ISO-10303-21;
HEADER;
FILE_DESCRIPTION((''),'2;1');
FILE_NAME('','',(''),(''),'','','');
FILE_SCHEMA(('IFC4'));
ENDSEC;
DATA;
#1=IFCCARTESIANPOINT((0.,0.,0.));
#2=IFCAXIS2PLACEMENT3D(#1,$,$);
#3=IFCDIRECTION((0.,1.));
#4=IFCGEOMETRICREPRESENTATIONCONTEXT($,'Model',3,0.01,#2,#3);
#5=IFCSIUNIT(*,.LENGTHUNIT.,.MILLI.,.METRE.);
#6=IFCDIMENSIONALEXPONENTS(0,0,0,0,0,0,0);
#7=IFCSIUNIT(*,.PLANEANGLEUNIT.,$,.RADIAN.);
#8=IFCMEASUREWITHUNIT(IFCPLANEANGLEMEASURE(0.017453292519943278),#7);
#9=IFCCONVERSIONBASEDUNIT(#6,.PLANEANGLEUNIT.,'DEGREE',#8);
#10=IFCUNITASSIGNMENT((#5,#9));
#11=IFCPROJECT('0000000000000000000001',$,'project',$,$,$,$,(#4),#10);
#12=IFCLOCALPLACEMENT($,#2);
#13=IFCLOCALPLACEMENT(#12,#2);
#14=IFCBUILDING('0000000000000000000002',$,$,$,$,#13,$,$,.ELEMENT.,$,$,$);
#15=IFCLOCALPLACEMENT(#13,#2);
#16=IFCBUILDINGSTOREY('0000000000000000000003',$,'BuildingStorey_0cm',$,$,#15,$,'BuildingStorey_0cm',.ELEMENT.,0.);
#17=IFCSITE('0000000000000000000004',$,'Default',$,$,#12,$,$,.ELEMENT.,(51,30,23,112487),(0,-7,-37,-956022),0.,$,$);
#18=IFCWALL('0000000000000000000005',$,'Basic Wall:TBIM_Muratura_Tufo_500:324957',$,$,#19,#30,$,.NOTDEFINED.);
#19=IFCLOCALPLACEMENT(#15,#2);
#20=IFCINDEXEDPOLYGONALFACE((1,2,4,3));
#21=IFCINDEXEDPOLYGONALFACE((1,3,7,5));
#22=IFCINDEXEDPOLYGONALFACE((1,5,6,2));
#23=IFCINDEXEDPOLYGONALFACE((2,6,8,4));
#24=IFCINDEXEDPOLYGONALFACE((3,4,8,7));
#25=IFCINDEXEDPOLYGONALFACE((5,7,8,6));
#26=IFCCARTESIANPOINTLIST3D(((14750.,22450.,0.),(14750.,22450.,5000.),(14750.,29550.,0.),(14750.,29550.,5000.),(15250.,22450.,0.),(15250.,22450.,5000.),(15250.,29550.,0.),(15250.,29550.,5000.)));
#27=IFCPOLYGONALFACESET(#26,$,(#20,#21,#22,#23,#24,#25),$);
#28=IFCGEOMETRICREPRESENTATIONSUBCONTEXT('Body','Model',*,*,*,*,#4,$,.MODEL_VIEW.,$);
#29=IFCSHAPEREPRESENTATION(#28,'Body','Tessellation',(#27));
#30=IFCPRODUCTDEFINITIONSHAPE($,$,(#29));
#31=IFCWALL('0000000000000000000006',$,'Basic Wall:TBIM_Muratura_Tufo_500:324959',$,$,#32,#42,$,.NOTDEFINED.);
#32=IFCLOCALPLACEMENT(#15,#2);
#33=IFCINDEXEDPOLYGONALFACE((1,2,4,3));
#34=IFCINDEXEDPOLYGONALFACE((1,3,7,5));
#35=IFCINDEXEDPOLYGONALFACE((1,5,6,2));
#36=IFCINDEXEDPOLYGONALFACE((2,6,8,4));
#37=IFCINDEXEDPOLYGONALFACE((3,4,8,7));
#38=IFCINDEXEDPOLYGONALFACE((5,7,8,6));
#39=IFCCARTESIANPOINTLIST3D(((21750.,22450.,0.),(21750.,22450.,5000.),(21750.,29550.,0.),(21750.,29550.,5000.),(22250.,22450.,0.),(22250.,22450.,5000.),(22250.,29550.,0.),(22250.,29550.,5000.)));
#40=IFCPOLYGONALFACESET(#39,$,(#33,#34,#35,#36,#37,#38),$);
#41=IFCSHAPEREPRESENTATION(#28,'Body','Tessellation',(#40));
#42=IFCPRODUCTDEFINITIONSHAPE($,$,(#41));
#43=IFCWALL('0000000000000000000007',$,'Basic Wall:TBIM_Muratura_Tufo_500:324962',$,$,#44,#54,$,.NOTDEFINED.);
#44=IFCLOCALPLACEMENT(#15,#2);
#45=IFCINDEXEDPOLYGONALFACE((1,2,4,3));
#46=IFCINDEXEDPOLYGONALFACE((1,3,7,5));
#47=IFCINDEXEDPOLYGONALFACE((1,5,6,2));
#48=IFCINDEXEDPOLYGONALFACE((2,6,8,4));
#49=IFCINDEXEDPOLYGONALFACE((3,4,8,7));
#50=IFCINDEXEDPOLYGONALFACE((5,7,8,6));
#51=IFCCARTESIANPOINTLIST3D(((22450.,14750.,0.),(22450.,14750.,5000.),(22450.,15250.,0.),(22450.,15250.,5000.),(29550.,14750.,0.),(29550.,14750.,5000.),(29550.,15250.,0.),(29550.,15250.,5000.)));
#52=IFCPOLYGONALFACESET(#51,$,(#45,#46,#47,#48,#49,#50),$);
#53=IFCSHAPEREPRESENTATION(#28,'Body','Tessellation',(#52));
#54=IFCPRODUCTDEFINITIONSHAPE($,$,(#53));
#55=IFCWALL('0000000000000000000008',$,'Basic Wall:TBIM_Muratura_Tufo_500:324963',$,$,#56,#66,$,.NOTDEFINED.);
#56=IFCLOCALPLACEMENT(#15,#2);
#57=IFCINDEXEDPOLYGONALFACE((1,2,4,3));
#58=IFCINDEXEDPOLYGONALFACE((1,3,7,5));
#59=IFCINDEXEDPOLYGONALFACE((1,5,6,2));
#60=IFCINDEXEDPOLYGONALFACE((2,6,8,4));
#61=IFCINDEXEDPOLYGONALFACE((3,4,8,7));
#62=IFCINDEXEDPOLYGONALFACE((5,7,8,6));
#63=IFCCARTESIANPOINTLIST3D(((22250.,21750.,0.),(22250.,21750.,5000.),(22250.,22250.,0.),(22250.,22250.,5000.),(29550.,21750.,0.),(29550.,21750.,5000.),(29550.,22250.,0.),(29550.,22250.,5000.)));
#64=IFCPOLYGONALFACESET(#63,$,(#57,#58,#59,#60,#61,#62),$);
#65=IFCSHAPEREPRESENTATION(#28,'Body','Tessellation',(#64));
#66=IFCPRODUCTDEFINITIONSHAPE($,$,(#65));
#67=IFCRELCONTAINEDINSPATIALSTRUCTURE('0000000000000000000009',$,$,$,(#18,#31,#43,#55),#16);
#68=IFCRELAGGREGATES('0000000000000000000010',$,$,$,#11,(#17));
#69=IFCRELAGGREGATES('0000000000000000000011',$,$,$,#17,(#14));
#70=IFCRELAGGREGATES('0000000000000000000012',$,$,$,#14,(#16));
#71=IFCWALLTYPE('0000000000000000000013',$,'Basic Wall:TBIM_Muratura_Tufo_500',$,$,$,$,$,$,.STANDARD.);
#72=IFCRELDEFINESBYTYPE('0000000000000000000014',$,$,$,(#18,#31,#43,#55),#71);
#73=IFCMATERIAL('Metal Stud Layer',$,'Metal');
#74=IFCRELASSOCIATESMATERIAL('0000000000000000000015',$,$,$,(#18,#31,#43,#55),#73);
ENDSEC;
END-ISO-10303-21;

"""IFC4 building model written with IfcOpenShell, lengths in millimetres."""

from ifc_helpers import new_model, entity, si_unit, converted_unit, direction, frame, origin, place, context, subcontext, project, spatial, indexed_curve, outline, extrude, material, type_object, element, save


model = new_model("IFC4")

# Units and contexts
model_context = context("Model", 3, precision=0.01, world=origin(), true_north=direction((0.0, 1.0)))
body_context = subcontext(model_context, "Body", "Model", "MODEL_VIEW")
ifc_project = project(units=[si_unit("LENGTHUNIT", "METRE", prefix="MILLI"), converted_unit("PLANEANGLEUNIT", "DEGREE", entity("IfcPlaneAngleMeasure", 0.017453292519943278), si_unit("PLANEANGLEUNIT", "RADIAN"), dimensions=[0, 0, 0, 0, 0, 0, 0])], contexts=[model_context])

# Site, building, storey
site_placement = place(None, origin())
site = spatial("IfcSite", under=ifc_project, at=site_placement, Name="Default", CompositionType="ELEMENT", RefLatitude=(51, 30, 23, 112487), RefLongitude=(0, -7, -37, -956022), RefElevation=0.0)
building_placement = place(site_placement, origin())
building = spatial("IfcBuilding", under=site, at=building_placement, CompositionType="ELEMENT")
storey_placement = place(building_placement, origin())
storey = spatial("IfcBuildingStorey", under=building, at=storey_placement, Name="BuildingStorey_0cm", LongName="BuildingStorey_0cm", CompositionType="ELEMENT", Elevation=0.0)

# Walls
ifc_material_1 = material(Name="Metal Stud Layer", Category="Metal")
wall_type_1 = type_object("IfcWallType", Name="Basic Wall:TBIM_Muratura_Tufo_500", PredefinedType="STANDARD")
wall_1_placement = place(storey_placement, frame((15000.0, 22450.0, 0.0), z_axis=(0.0, 0.0, 1.0), x_axis=(0.0, 1.0, 0.0)))
element("IfcWall", 1, at=wall_1_placement, inside=storey, type_object=wall_type_1, material=ifc_material_1, Name="Basic Wall:TBIM_Muratura_Tufo_500:324957", PredefinedType="NOTDEFINED", context=body_context, shape_type="SweptSolid", body=[
    extrude(outline(indexed_curve([(7100.0, 250.0), (0.0, 250.0), (0.0, -250.0), (7100.0, -250.0), (7100.0, 250.0)], self_intersect=False)), origin(), (0.0, 0.0, 1.0), 5000.0),
])
wall_2_placement = place(storey_placement, frame((22000.0, 22450.0, 0.0), z_axis=(0.0, 0.0, 1.0), x_axis=(0.0, 1.0, 0.0)))
element("IfcWall", 2, at=wall_2_placement, inside=storey, type_object=wall_type_1, material=ifc_material_1, Name="Basic Wall:TBIM_Muratura_Tufo_500:324959", PredefinedType="NOTDEFINED", context=body_context, shape_type="SweptSolid", body=[
    extrude(outline(indexed_curve([(7100.0, 250.0), (0.0, 250.0), (0.0, -250.0), (7100.0, -250.0), (7100.0, 250.0)], self_intersect=False)), origin(), (0.0, 0.0, 1.0), 5000.0),
])
wall_3_placement = place(storey_placement, frame((22450.0, 15000.0, 0.0)))
element("IfcWall", 3, at=wall_3_placement, inside=storey, type_object=wall_type_1, material=ifc_material_1, Name="Basic Wall:TBIM_Muratura_Tufo_500:324962", PredefinedType="NOTDEFINED", context=body_context, shape_type="SweptSolid", body=[
    extrude(outline(indexed_curve([(7100.0, 250.0), (0.0, 250.0), (0.0, -250.0), (7100.0, -250.0), (7100.0, 250.0)], self_intersect=False)), origin(), (0.0, 0.0, 1.0), 5000.0),
])
wall_4_placement = place(storey_placement, frame((22250.0, 22000.0, 0.0)))
element("IfcWall", 4, at=wall_4_placement, inside=storey, type_object=wall_type_1, material=ifc_material_1, Name="Basic Wall:TBIM_Muratura_Tufo_500:324963", PredefinedType="NOTDEFINED", context=body_context, shape_type="SweptSolid", body=[
    extrude(outline(indexed_curve([(7300.0, 250.0), (0.0, 250.0), (0.0, -250.0), (7300.0, -250.0), (7300.0, 250.0)], self_intersect=False)), origin(), (0.0, 0.0, 1.0), 5000.0),
])

save(model, "model.ifc")
